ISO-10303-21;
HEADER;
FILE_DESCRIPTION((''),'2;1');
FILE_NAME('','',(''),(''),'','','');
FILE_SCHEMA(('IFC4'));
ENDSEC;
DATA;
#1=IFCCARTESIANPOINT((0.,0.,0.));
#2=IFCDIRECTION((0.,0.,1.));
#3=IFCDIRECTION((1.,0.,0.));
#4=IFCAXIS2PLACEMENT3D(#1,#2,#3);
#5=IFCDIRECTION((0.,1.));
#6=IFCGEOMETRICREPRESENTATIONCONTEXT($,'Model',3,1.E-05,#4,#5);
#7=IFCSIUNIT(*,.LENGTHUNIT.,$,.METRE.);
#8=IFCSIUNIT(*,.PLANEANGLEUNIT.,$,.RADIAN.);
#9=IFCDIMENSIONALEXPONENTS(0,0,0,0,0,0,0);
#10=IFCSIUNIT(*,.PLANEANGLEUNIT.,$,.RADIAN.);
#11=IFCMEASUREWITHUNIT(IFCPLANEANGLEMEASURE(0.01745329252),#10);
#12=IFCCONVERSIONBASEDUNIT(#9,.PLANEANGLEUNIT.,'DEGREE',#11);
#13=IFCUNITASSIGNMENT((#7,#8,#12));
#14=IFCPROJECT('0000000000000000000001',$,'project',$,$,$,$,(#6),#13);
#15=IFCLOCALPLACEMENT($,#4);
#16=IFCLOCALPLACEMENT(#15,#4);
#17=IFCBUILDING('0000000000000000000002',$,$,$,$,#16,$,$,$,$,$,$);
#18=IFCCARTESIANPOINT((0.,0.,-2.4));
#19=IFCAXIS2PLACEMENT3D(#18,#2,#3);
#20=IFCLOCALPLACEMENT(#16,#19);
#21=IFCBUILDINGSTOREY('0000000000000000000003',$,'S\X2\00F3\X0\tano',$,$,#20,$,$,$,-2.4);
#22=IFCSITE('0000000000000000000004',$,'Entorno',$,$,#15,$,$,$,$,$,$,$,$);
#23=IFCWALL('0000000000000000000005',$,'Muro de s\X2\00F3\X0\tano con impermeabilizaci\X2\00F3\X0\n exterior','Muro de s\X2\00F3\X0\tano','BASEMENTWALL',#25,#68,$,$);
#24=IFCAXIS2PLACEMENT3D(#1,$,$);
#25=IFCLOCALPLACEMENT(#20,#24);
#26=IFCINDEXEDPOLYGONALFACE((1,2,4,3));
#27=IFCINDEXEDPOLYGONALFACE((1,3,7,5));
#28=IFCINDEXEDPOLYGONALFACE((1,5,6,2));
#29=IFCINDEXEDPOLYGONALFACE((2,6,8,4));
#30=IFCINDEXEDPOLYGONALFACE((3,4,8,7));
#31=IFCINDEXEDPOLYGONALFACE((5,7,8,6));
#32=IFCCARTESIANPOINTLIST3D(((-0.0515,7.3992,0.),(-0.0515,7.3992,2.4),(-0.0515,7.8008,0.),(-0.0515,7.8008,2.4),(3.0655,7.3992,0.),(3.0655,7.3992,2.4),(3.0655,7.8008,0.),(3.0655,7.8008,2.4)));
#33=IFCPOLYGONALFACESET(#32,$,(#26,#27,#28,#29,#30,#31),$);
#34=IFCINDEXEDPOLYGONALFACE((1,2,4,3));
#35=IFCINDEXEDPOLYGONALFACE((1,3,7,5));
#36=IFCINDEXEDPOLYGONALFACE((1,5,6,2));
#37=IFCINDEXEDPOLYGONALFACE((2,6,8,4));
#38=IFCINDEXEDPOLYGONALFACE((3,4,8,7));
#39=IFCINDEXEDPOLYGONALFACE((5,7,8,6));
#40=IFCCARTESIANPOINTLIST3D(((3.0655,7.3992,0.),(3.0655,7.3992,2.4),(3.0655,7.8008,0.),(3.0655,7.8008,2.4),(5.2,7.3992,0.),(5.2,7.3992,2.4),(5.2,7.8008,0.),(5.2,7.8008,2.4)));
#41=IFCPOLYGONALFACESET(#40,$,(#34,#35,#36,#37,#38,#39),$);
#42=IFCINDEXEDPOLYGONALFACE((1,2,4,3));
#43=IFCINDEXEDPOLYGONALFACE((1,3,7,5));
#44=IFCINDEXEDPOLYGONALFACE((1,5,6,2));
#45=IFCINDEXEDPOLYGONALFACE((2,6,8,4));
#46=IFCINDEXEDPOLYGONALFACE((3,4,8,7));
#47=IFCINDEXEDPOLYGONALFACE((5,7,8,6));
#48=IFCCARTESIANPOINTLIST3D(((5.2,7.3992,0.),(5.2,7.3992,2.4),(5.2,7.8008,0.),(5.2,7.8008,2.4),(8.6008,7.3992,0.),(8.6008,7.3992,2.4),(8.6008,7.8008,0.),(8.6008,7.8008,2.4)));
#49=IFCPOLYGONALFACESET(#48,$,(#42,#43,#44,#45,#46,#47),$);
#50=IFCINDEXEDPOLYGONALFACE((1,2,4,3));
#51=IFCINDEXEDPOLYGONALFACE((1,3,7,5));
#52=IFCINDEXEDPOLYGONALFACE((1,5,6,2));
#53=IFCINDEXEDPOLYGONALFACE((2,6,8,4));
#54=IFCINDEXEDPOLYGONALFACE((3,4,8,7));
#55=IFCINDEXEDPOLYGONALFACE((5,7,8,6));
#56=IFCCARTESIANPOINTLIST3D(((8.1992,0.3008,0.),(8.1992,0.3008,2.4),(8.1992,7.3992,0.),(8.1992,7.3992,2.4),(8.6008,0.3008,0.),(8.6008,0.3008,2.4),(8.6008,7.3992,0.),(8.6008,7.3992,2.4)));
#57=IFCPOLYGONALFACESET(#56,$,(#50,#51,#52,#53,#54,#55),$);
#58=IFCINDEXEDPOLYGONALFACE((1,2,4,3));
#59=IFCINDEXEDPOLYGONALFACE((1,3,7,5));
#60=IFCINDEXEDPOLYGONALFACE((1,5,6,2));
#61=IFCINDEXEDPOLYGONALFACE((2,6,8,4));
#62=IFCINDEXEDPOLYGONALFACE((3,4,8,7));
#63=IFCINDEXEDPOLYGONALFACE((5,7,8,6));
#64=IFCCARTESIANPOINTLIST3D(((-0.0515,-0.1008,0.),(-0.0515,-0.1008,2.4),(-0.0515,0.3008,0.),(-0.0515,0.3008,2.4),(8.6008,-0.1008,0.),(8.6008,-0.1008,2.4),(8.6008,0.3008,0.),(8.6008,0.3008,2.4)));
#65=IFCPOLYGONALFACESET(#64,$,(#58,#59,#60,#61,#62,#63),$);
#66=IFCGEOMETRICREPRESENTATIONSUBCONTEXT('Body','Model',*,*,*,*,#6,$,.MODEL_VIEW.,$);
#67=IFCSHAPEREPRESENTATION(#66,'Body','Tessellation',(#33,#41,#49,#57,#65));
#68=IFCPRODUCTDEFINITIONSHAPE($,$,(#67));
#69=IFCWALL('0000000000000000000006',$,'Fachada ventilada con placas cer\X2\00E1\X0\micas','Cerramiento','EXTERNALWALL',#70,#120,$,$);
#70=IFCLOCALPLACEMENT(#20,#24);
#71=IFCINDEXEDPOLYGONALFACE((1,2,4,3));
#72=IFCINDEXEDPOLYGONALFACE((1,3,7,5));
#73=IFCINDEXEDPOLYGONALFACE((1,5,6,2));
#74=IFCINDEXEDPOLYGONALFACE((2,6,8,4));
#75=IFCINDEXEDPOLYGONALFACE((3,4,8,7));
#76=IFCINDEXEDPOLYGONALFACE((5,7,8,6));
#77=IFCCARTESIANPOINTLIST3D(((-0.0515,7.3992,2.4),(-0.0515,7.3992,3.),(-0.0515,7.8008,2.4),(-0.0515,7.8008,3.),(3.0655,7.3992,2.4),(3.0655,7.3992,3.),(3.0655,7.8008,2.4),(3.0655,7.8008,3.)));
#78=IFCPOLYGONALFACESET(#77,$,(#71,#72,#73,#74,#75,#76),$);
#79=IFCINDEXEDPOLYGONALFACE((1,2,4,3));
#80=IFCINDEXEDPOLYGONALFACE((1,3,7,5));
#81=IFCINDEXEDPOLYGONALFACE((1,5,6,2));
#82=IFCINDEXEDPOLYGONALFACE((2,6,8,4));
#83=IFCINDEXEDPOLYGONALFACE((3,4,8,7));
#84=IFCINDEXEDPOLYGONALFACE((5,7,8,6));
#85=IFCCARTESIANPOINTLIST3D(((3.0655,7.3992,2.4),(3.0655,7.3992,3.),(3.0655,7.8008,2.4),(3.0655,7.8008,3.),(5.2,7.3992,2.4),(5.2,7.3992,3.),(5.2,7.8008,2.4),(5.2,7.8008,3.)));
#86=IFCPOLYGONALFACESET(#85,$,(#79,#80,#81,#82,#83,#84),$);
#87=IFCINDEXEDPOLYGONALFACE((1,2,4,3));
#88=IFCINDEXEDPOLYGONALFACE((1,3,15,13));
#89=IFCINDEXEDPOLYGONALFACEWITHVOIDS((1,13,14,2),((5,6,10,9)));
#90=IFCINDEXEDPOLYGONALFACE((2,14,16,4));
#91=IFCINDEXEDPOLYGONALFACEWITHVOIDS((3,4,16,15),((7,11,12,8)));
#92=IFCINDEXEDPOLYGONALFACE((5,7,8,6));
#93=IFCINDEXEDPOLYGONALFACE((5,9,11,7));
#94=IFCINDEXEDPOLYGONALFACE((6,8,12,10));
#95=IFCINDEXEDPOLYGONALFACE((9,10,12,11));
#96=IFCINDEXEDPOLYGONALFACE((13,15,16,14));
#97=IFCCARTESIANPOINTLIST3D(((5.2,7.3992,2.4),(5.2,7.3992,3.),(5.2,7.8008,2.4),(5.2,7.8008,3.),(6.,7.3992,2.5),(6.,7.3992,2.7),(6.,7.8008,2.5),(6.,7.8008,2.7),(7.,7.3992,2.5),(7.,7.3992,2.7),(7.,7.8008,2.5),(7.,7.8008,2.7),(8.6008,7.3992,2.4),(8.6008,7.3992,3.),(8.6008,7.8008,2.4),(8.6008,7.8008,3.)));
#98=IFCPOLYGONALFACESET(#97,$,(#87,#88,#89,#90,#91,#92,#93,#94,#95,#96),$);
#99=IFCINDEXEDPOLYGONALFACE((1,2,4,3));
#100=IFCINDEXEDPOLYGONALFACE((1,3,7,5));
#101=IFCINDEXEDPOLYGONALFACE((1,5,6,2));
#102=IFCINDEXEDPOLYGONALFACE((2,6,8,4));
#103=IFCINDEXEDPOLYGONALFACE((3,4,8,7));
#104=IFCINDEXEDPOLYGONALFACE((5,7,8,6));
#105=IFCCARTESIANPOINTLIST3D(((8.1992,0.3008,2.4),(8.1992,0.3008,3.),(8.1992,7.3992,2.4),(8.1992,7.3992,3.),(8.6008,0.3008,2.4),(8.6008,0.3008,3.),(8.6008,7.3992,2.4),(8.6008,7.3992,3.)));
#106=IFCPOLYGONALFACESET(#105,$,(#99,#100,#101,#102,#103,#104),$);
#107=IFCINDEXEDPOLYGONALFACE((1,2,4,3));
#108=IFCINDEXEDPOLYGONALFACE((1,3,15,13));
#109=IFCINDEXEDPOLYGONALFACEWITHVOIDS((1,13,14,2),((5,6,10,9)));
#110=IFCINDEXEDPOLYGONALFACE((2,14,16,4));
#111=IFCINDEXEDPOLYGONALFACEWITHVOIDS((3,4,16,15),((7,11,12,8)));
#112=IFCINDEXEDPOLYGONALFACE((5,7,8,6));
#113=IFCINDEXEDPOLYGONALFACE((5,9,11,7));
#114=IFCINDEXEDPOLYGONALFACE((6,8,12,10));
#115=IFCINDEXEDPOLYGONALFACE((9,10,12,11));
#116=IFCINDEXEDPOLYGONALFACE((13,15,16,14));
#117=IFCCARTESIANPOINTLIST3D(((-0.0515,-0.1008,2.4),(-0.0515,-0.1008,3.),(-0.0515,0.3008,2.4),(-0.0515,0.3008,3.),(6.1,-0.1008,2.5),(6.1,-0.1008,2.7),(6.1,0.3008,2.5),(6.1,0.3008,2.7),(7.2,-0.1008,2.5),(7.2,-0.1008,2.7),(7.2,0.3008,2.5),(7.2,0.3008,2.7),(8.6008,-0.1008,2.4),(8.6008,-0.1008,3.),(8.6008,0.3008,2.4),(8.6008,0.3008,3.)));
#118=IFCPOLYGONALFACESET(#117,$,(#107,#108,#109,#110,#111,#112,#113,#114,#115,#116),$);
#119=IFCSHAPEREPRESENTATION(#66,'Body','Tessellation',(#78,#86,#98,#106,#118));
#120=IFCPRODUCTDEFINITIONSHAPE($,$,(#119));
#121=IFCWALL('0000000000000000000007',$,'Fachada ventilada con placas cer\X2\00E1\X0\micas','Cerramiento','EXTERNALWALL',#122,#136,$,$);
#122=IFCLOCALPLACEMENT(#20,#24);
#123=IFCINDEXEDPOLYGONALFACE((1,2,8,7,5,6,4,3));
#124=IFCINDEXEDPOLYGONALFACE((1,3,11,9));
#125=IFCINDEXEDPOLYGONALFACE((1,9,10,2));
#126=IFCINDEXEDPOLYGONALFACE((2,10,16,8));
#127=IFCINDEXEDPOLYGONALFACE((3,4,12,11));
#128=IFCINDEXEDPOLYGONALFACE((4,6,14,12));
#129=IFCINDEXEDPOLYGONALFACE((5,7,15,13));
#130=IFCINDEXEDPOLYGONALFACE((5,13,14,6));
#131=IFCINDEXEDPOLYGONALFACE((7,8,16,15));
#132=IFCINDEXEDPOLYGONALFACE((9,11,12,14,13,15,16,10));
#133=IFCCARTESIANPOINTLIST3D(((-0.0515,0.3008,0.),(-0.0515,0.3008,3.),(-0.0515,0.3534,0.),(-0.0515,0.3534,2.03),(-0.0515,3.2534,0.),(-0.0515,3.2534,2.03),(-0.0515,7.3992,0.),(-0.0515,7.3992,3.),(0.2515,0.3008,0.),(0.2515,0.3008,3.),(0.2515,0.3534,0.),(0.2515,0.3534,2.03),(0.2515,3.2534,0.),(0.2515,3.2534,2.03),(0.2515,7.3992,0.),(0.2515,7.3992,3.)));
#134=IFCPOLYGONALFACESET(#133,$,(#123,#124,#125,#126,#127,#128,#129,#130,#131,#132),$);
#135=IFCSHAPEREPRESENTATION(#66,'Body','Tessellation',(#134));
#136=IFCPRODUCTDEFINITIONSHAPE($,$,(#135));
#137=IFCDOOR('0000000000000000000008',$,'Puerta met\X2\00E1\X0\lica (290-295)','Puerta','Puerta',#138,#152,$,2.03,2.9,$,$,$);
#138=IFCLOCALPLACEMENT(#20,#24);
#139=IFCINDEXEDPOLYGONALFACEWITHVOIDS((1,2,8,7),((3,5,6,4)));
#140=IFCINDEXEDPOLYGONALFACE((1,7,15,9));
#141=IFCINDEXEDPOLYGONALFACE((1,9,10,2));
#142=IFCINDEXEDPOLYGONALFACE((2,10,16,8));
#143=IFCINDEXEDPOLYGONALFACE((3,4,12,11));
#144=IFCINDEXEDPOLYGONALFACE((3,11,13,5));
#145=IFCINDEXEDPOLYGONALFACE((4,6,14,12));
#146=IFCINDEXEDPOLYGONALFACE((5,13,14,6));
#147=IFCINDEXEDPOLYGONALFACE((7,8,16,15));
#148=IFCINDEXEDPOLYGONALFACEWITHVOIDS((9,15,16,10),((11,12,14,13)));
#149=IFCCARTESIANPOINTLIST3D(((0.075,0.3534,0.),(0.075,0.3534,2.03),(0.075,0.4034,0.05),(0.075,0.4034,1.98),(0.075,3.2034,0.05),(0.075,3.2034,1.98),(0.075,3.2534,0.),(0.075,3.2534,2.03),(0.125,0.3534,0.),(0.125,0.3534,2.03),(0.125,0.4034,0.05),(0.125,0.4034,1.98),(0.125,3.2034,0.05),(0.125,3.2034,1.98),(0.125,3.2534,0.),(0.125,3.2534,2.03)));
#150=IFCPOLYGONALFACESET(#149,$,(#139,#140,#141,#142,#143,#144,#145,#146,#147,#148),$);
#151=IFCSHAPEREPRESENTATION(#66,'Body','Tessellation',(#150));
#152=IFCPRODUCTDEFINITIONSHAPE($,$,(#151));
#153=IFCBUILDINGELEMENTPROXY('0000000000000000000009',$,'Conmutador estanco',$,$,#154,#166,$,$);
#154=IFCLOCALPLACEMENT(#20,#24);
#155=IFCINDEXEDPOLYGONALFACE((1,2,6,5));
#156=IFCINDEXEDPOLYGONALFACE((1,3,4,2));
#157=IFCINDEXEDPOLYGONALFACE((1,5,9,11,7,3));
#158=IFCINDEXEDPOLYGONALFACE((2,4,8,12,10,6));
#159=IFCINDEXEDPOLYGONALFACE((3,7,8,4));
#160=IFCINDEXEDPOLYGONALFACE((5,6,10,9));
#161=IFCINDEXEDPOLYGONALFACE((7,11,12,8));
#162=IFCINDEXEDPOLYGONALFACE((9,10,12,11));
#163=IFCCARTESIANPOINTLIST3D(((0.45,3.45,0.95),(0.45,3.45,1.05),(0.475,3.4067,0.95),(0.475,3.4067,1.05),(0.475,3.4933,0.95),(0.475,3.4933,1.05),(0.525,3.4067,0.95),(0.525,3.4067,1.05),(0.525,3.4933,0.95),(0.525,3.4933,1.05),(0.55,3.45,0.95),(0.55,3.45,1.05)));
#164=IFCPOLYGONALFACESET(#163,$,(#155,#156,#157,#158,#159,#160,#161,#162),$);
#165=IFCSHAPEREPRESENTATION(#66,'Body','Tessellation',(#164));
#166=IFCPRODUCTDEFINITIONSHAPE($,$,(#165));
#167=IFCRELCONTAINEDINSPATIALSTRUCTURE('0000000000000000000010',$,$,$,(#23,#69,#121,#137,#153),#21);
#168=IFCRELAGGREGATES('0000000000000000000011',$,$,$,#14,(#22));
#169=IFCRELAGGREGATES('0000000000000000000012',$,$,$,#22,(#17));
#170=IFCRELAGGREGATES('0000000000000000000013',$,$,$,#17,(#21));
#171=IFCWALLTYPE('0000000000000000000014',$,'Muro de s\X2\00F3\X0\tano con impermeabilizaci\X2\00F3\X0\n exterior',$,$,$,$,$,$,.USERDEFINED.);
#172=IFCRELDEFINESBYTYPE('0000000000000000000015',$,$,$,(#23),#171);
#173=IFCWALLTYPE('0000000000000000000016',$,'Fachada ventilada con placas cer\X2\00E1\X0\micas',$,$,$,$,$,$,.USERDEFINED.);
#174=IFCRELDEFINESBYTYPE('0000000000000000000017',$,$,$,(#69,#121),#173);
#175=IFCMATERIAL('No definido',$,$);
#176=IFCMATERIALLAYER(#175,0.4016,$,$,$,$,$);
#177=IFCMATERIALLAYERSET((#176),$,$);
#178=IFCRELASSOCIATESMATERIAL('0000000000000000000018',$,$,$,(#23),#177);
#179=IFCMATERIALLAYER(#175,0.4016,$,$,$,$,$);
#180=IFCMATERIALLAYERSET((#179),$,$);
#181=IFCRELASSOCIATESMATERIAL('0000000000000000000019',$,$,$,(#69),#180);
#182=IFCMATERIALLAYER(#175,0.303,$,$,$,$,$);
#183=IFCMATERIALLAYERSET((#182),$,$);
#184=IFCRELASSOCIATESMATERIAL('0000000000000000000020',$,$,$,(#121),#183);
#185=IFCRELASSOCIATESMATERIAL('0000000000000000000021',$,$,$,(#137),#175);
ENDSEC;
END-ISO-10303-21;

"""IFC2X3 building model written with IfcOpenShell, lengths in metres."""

from ifc_helpers import new_model, entity, si_unit, converted_unit, direction, frame, origin_with_axes, origin_2d_with_axis, place, context, subcontext, project, spatial, polyline, rectangle, hollow_rectangle, outline, extrude, shape, source, transform, mapped, material, layer, layer_set, layer_usage, type_object, element, fill, save


model = new_model("IFC2X3")

# Units and contexts
model_context = context("Model", 3, precision=1e-05, world=origin_with_axes(), true_north=direction((0.0, 1.0)))
body_context = subcontext(model_context, "Body", "Model", "MODEL_VIEW")
footprint_context = subcontext(model_context, "FootPrint", "Model", "MODEL_VIEW")
ifc_project = project(units=[si_unit("LENGTHUNIT", "METRE"), si_unit("PLANEANGLEUNIT", "RADIAN"), converted_unit("PLANEANGLEUNIT", "DEGREE", entity("IfcPlaneAngleMeasure", 0.01745329252), si_unit("PLANEANGLEUNIT", "RADIAN"), dimensions=[0, 0, 0, 0, 0, 0, 0])], contexts=[model_context])

# Site, building, storey
site_placement = place(None, origin_with_axes())
site = spatial("IfcSite", under=ifc_project, at=site_placement, Name="Entorno")
building_placement = place(site_placement, origin_with_axes())
building = spatial("IfcBuilding", under=site, at=building_placement)
storey_placement = place(building_placement, frame((0.0, 0.0, -2.4), z_axis=(0.0, 0.0, 1.0), x_axis=(1.0, 0.0, 0.0)))
storey = spatial("IfcBuildingStorey", under=building, at=storey_placement, Name="Sótano", Elevation=-2.4)

# Shared definitions
ifc_material = material(Name="No definido")

# Wall
ifc_layer_1 = layer(ifc_material, 0.4016)
ifc_layer_set_1 = layer_set([ifc_layer_1])
ifc_layer_usage_1 = layer_usage(ifc_layer_set_1, "AXIS2", "POSITIVE", -0.2008)
wall_type_1 = type_object("IfcWallType", Name="Muro de sótano con impermeabilización exterior", PredefinedType="USERDEFINED")
wall_1_placement = place(storey_placement, frame((0.1, 7.6, 0.0), z_axis=(0.0, 0.0, 1.0), x_axis=(1.0, 0.0, 0.0)))
element("IfcWall", 1, at=wall_1_placement, inside=storey, type_object=wall_type_1, material=ifc_layer_usage_1, Name="Muro de sótano con impermeabilización exterior", Description="Muro de sótano", ObjectType="BASEMENTWALL", context=body_context, shape_type="SolidModel", body=[
    extrude(outline(polyline([(-1.5585, -1.2), (1.5585, -1.2), (1.5585, 1.2), (-1.5585, 1.2), (-1.5585, -1.2)])), frame((1.407, 0.2008, 1.2), z_axis=(0.0, -1.0, 0.0), x_axis=(1.0, 0.0, 0.0)), (0.0, 0.0, 1.0), 0.4016),
    extrude(outline(polyline([(-1.0673, -1.2), (1.0673, -1.2), (1.0673, 1.2), (-1.0673, 1.2), (-1.0673, -1.2)])), frame((4.0328, 0.2008, 1.2), z_axis=(0.0, -1.0, 0.0), x_axis=(1.0, 0.0, 0.0)), (0.0, 0.0, 1.0), 0.4016),
    extrude(outline(polyline([(-1.7004, -1.2), (1.7004, -1.2), (1.7004, 1.2), (-1.7004, 1.2), (-1.7004, -1.2)])), frame((6.8004, 0.2008, 1.2), z_axis=(0.0, -1.0, 0.0), x_axis=(1.0, 0.0, 0.0)), (0.0, 0.0, 1.0), 0.4016),
    extrude(outline(polyline([(-3.5492, -1.2), (3.5492, -1.2), (3.5492, 1.2), (-3.5492, 1.2), (-3.5492, -1.2)])), frame((8.5008, -3.75, 1.2), z_axis=(-1.0, 0.0, 0.0), x_axis=(0.0, -1.0, 0.0)), (0.0, 0.0, 1.0), 0.4016),
    extrude(outline(polyline([(-4.3262, -1.2), (4.3262, -1.2), (4.3262, 1.2), (-4.3262, 1.2), (-4.3262, -1.2)])), frame((4.1746, -7.7008, 1.2), z_axis=(0.0, 1.0, 0.0), x_axis=(-1.0, 0.0, 0.0)), (0.0, 0.0, 1.0), 0.4016),
])

# Wall, openings
ifc_layer_2 = layer(ifc_material, 0.4016)
ifc_layer_set_2 = layer_set([ifc_layer_2])
ifc_layer_usage_2 = layer_usage(ifc_layer_set_2, "AXIS2", "POSITIVE", -0.2008)
wall_type_2 = type_object("IfcWallType", Name="Fachada ventilada con placas cerámicas", PredefinedType="USERDEFINED")
wall_2_placement = place(storey_placement, frame((0.1, 7.6, 0.0), z_axis=(0.0, 0.0, 1.0), x_axis=(1.0, 0.0, 0.0)))
wall_2 = element("IfcWall", 2, at=wall_2_placement, inside=storey, type_object=wall_type_2, material=ifc_layer_usage_2, Name="Fachada ventilada con placas cerámicas", Description="Cerramiento", ObjectType="EXTERNALWALL", context=body_context, shape_type="SolidModel", body=[
    extrude(outline(polyline([(-1.5585, -0.3), (1.5585, -0.3), (1.5585, 0.3), (-1.5585, 0.3), (-1.5585, -0.3)])), frame((1.407, 0.2008, 2.7), z_axis=(0.0, -1.0, 0.0), x_axis=(1.0, 0.0, 0.0)), (0.0, 0.0, 1.0), 0.4016),
    extrude(outline(polyline([(-1.0673, -0.3), (1.0673, -0.3), (1.0673, 0.3), (-1.0673, 0.3), (-1.0673, -0.3)])), frame((4.0328, 0.2008, 2.7), z_axis=(0.0, -1.0, 0.0), x_axis=(1.0, 0.0, 0.0)), (0.0, 0.0, 1.0), 0.4016),
    extrude(outline(polyline([(-1.7004, -0.3), (1.7004, -0.3), (1.7004, 0.3), (-1.7004, 0.3), (-1.7004, -0.3)])), frame((6.8004, 0.2008, 2.7), z_axis=(0.0, -1.0, 0.0), x_axis=(1.0, 0.0, 0.0)), (0.0, 0.0, 1.0), 0.4016),
    extrude(outline(polyline([(-3.5492, -0.3), (3.5492, -0.3), (3.5492, 0.3), (-3.5492, 0.3), (-3.5492, -0.3)])), frame((8.5008, -3.75, 2.7), z_axis=(-1.0, 0.0, 0.0), x_axis=(0.0, -1.0, 0.0)), (0.0, 0.0, 1.0), 0.4016),
    extrude(outline(polyline([(-4.3262, -0.3), (4.3262, -0.3), (4.3262, 0.3), (-4.3262, 0.3), (-4.3262, -0.3)])), frame((4.1746, -7.7008, 2.7), z_axis=(0.0, 1.0, 0.0), x_axis=(-1.0, 0.0, 0.0)), (0.0, 0.0, 1.0), 0.4016),
])
opening_1_placement = place(wall_2_placement, frame((6.4, 0.0, 2.6), z_axis=(0.0, 0.0, 1.0), x_axis=(1.0, 0.0, 0.0)))
cartesian_point_1 = entity("IfcCartesianPoint", [-0.5, -0.2008])
element("IfcOpeningElement", 3, at=opening_1_placement, cuts=wall_2, ObjectType="No definido", shapes=[
    shape(body_context, "Body", "SweptSolid", [extrude(rectangle(XDim=0.2, YDim=1.0, at=origin_2d_with_axis()), frame((0.0, -0.2008, 0.0), z_axis=(0.0, 1.0, 0.0), x_axis=(0.0, 0.0, 1.0)), (0.0, 0.0, 1.0), 0.4016)]),
    shape(footprint_context, "FootPrint", "GeometricCurveSet", [entity("IfcGeometricCurveSet", [entity("IfcPolyline", [cartesian_point_1, entity("IfcCartesianPoint", [0.5, -0.2008]), entity("IfcCartesianPoint", [0.5, 0.2008]), entity("IfcCartesianPoint", [-0.5, 0.2008]), cartesian_point_1])])]),
])
opening_2_placement = place(wall_2_placement, frame((6.55, -7.5, 2.6), z_axis=(0.0, 0.0, 1.0), x_axis=(-1.0, 0.0, 0.0)))
cartesian_point_2 = entity("IfcCartesianPoint", [-0.55, -0.2008])
element("IfcOpeningElement", 4, at=opening_2_placement, cuts=wall_2, ObjectType="No definido", shapes=[
    shape(body_context, "Body", "SweptSolid", [extrude(rectangle(XDim=0.2, YDim=1.1, at=origin_2d_with_axis()), frame((0.0, -0.2008, 0.0), z_axis=(0.0, 1.0, 0.0), x_axis=(0.0, 0.0, 1.0)), (0.0, 0.0, 1.0), 0.4016)]),
    shape(footprint_context, "FootPrint", "GeometricCurveSet", [entity("IfcGeometricCurveSet", [entity("IfcPolyline", [cartesian_point_2, entity("IfcCartesianPoint", [0.55, -0.2008]), entity("IfcCartesianPoint", [0.55, 0.2008]), entity("IfcCartesianPoint", [-0.55, 0.2008]), cartesian_point_2])])]),
])

# Wall, opening, door
ifc_layer_3 = layer(ifc_material, 0.303)
ifc_layer_set_3 = layer_set([ifc_layer_3])
ifc_layer_usage_3 = layer_usage(ifc_layer_set_3, "AXIS2", "POSITIVE", -0.1515)
wall_3_placement = place(storey_placement, frame((0.1, 0.1, 0.0), z_axis=(0.0, 0.0, 1.0), x_axis=(0.0, 1.0, 0.0)))
wall_3 = element("IfcWall", 5, at=wall_3_placement, inside=storey, type_object=wall_type_2, material=ifc_layer_usage_3, Name="Fachada ventilada con placas cerámicas", Description="Cerramiento", ObjectType="EXTERNALWALL", context=body_context, shape_type="SolidModel", body=[
    extrude(outline(polyline([(-3.5492, -1.5), (3.5492, -1.5), (3.5492, 1.5), (-3.5492, 1.5), (-3.5492, -1.5)])), frame((3.75, 0.1515, 1.5), z_axis=(0.0, -1.0, 0.0), x_axis=(1.0, 0.0, 0.0)), (0.0, 0.0, 1.0), 0.303),
])
opening_3_placement = place(wall_3_placement, frame((1.7034, 0.0, 1.015), z_axis=(0.0, 0.0, 1.0), x_axis=(1.0, 0.0, 0.0)))
cartesian_point_3 = entity("IfcCartesianPoint", [-1.45, -0.1515])
opening_3 = element("IfcOpeningElement", 6, at=opening_3_placement, cuts=wall_3, ObjectType="No definido", shapes=[
    shape(body_context, "Body", "SweptSolid", [extrude(rectangle(XDim=2.03, YDim=2.9, at=origin_2d_with_axis()), frame((0.0, -0.1515, 0.0), z_axis=(0.0, 1.0, 0.0), x_axis=(0.0, 0.0, 1.0)), (0.0, 0.0, 1.0), 0.303)]),
    shape(footprint_context, "FootPrint", "GeometricCurveSet", [entity("IfcGeometricCurveSet", [entity("IfcPolyline", [cartesian_point_3, entity("IfcCartesianPoint", [1.45, -0.1515]), entity("IfcCartesianPoint", [1.45, 0.1515]), entity("IfcCartesianPoint", [-1.45, 0.1515]), cartesian_point_3])])]),
])
door_1_placement = place(opening_3_placement, origin_with_axes())
door_1 = element("IfcDoor", 7, at=door_1_placement, inside=storey, material=ifc_material, Name="Puerta metálica (290-295)", Description="Puerta", ObjectType="Puerta", OverallHeight=2.03, OverallWidth=2.9, context=body_context, shape_type="SweptSolid", body=[
    extrude(hollow_rectangle(XDim=2.9, YDim=2.03, WallThickness=0.05, InnerFilletRadius=0.0, OuterFilletRadius=0.0, at=origin_2d_with_axis()), frame((0.0, 0.025, 0.0), z_axis=(0.0, -1.0, 0.0), x_axis=(1.0, 0.0, 0.0)), (0.0, 0.0, 1.0), 0.05),
])
fill(opening_3, door_1)

# Building element proxy
shared_shape_1 = source(origin_with_axes(), body_context, "Body", "SolidModel", [
    extrude(outline(polyline([(0.05, 0.0), (0.025, 0.0433), (-0.025, 0.0433), (-0.05, 0.0), (-0.025, -0.0433), (0.025, -0.0433), (0.05, 0.0)])), frame((0.0, 0.0, -0.05), z_axis=(0.0, 0.0, 1.0), x_axis=(1.0, 0.0, 0.0)), (0.0, 0.0, 1.0), 0.1),
])
proxy_1_placement = place(storey_placement, frame((0.0, 0.0, 2.4), z_axis=(0.0, 0.0, 1.0), x_axis=(1.0, 0.0, 0.0)))
element("IfcBuildingElementProxy", 8, at=proxy_1_placement, inside=storey, Name="Conmutador estanco", context=body_context, shape_type="Brep", body=[
    mapped(shared_shape_1, transform((0.5, 3.45, -1.4), x_axis=(1.0, 0.0, 0.0), y_axis=(0.0, 1.0, 0.0), z_axis=(0.0, 0.0, 1.0))),
])

save(model, "model.ifc")
